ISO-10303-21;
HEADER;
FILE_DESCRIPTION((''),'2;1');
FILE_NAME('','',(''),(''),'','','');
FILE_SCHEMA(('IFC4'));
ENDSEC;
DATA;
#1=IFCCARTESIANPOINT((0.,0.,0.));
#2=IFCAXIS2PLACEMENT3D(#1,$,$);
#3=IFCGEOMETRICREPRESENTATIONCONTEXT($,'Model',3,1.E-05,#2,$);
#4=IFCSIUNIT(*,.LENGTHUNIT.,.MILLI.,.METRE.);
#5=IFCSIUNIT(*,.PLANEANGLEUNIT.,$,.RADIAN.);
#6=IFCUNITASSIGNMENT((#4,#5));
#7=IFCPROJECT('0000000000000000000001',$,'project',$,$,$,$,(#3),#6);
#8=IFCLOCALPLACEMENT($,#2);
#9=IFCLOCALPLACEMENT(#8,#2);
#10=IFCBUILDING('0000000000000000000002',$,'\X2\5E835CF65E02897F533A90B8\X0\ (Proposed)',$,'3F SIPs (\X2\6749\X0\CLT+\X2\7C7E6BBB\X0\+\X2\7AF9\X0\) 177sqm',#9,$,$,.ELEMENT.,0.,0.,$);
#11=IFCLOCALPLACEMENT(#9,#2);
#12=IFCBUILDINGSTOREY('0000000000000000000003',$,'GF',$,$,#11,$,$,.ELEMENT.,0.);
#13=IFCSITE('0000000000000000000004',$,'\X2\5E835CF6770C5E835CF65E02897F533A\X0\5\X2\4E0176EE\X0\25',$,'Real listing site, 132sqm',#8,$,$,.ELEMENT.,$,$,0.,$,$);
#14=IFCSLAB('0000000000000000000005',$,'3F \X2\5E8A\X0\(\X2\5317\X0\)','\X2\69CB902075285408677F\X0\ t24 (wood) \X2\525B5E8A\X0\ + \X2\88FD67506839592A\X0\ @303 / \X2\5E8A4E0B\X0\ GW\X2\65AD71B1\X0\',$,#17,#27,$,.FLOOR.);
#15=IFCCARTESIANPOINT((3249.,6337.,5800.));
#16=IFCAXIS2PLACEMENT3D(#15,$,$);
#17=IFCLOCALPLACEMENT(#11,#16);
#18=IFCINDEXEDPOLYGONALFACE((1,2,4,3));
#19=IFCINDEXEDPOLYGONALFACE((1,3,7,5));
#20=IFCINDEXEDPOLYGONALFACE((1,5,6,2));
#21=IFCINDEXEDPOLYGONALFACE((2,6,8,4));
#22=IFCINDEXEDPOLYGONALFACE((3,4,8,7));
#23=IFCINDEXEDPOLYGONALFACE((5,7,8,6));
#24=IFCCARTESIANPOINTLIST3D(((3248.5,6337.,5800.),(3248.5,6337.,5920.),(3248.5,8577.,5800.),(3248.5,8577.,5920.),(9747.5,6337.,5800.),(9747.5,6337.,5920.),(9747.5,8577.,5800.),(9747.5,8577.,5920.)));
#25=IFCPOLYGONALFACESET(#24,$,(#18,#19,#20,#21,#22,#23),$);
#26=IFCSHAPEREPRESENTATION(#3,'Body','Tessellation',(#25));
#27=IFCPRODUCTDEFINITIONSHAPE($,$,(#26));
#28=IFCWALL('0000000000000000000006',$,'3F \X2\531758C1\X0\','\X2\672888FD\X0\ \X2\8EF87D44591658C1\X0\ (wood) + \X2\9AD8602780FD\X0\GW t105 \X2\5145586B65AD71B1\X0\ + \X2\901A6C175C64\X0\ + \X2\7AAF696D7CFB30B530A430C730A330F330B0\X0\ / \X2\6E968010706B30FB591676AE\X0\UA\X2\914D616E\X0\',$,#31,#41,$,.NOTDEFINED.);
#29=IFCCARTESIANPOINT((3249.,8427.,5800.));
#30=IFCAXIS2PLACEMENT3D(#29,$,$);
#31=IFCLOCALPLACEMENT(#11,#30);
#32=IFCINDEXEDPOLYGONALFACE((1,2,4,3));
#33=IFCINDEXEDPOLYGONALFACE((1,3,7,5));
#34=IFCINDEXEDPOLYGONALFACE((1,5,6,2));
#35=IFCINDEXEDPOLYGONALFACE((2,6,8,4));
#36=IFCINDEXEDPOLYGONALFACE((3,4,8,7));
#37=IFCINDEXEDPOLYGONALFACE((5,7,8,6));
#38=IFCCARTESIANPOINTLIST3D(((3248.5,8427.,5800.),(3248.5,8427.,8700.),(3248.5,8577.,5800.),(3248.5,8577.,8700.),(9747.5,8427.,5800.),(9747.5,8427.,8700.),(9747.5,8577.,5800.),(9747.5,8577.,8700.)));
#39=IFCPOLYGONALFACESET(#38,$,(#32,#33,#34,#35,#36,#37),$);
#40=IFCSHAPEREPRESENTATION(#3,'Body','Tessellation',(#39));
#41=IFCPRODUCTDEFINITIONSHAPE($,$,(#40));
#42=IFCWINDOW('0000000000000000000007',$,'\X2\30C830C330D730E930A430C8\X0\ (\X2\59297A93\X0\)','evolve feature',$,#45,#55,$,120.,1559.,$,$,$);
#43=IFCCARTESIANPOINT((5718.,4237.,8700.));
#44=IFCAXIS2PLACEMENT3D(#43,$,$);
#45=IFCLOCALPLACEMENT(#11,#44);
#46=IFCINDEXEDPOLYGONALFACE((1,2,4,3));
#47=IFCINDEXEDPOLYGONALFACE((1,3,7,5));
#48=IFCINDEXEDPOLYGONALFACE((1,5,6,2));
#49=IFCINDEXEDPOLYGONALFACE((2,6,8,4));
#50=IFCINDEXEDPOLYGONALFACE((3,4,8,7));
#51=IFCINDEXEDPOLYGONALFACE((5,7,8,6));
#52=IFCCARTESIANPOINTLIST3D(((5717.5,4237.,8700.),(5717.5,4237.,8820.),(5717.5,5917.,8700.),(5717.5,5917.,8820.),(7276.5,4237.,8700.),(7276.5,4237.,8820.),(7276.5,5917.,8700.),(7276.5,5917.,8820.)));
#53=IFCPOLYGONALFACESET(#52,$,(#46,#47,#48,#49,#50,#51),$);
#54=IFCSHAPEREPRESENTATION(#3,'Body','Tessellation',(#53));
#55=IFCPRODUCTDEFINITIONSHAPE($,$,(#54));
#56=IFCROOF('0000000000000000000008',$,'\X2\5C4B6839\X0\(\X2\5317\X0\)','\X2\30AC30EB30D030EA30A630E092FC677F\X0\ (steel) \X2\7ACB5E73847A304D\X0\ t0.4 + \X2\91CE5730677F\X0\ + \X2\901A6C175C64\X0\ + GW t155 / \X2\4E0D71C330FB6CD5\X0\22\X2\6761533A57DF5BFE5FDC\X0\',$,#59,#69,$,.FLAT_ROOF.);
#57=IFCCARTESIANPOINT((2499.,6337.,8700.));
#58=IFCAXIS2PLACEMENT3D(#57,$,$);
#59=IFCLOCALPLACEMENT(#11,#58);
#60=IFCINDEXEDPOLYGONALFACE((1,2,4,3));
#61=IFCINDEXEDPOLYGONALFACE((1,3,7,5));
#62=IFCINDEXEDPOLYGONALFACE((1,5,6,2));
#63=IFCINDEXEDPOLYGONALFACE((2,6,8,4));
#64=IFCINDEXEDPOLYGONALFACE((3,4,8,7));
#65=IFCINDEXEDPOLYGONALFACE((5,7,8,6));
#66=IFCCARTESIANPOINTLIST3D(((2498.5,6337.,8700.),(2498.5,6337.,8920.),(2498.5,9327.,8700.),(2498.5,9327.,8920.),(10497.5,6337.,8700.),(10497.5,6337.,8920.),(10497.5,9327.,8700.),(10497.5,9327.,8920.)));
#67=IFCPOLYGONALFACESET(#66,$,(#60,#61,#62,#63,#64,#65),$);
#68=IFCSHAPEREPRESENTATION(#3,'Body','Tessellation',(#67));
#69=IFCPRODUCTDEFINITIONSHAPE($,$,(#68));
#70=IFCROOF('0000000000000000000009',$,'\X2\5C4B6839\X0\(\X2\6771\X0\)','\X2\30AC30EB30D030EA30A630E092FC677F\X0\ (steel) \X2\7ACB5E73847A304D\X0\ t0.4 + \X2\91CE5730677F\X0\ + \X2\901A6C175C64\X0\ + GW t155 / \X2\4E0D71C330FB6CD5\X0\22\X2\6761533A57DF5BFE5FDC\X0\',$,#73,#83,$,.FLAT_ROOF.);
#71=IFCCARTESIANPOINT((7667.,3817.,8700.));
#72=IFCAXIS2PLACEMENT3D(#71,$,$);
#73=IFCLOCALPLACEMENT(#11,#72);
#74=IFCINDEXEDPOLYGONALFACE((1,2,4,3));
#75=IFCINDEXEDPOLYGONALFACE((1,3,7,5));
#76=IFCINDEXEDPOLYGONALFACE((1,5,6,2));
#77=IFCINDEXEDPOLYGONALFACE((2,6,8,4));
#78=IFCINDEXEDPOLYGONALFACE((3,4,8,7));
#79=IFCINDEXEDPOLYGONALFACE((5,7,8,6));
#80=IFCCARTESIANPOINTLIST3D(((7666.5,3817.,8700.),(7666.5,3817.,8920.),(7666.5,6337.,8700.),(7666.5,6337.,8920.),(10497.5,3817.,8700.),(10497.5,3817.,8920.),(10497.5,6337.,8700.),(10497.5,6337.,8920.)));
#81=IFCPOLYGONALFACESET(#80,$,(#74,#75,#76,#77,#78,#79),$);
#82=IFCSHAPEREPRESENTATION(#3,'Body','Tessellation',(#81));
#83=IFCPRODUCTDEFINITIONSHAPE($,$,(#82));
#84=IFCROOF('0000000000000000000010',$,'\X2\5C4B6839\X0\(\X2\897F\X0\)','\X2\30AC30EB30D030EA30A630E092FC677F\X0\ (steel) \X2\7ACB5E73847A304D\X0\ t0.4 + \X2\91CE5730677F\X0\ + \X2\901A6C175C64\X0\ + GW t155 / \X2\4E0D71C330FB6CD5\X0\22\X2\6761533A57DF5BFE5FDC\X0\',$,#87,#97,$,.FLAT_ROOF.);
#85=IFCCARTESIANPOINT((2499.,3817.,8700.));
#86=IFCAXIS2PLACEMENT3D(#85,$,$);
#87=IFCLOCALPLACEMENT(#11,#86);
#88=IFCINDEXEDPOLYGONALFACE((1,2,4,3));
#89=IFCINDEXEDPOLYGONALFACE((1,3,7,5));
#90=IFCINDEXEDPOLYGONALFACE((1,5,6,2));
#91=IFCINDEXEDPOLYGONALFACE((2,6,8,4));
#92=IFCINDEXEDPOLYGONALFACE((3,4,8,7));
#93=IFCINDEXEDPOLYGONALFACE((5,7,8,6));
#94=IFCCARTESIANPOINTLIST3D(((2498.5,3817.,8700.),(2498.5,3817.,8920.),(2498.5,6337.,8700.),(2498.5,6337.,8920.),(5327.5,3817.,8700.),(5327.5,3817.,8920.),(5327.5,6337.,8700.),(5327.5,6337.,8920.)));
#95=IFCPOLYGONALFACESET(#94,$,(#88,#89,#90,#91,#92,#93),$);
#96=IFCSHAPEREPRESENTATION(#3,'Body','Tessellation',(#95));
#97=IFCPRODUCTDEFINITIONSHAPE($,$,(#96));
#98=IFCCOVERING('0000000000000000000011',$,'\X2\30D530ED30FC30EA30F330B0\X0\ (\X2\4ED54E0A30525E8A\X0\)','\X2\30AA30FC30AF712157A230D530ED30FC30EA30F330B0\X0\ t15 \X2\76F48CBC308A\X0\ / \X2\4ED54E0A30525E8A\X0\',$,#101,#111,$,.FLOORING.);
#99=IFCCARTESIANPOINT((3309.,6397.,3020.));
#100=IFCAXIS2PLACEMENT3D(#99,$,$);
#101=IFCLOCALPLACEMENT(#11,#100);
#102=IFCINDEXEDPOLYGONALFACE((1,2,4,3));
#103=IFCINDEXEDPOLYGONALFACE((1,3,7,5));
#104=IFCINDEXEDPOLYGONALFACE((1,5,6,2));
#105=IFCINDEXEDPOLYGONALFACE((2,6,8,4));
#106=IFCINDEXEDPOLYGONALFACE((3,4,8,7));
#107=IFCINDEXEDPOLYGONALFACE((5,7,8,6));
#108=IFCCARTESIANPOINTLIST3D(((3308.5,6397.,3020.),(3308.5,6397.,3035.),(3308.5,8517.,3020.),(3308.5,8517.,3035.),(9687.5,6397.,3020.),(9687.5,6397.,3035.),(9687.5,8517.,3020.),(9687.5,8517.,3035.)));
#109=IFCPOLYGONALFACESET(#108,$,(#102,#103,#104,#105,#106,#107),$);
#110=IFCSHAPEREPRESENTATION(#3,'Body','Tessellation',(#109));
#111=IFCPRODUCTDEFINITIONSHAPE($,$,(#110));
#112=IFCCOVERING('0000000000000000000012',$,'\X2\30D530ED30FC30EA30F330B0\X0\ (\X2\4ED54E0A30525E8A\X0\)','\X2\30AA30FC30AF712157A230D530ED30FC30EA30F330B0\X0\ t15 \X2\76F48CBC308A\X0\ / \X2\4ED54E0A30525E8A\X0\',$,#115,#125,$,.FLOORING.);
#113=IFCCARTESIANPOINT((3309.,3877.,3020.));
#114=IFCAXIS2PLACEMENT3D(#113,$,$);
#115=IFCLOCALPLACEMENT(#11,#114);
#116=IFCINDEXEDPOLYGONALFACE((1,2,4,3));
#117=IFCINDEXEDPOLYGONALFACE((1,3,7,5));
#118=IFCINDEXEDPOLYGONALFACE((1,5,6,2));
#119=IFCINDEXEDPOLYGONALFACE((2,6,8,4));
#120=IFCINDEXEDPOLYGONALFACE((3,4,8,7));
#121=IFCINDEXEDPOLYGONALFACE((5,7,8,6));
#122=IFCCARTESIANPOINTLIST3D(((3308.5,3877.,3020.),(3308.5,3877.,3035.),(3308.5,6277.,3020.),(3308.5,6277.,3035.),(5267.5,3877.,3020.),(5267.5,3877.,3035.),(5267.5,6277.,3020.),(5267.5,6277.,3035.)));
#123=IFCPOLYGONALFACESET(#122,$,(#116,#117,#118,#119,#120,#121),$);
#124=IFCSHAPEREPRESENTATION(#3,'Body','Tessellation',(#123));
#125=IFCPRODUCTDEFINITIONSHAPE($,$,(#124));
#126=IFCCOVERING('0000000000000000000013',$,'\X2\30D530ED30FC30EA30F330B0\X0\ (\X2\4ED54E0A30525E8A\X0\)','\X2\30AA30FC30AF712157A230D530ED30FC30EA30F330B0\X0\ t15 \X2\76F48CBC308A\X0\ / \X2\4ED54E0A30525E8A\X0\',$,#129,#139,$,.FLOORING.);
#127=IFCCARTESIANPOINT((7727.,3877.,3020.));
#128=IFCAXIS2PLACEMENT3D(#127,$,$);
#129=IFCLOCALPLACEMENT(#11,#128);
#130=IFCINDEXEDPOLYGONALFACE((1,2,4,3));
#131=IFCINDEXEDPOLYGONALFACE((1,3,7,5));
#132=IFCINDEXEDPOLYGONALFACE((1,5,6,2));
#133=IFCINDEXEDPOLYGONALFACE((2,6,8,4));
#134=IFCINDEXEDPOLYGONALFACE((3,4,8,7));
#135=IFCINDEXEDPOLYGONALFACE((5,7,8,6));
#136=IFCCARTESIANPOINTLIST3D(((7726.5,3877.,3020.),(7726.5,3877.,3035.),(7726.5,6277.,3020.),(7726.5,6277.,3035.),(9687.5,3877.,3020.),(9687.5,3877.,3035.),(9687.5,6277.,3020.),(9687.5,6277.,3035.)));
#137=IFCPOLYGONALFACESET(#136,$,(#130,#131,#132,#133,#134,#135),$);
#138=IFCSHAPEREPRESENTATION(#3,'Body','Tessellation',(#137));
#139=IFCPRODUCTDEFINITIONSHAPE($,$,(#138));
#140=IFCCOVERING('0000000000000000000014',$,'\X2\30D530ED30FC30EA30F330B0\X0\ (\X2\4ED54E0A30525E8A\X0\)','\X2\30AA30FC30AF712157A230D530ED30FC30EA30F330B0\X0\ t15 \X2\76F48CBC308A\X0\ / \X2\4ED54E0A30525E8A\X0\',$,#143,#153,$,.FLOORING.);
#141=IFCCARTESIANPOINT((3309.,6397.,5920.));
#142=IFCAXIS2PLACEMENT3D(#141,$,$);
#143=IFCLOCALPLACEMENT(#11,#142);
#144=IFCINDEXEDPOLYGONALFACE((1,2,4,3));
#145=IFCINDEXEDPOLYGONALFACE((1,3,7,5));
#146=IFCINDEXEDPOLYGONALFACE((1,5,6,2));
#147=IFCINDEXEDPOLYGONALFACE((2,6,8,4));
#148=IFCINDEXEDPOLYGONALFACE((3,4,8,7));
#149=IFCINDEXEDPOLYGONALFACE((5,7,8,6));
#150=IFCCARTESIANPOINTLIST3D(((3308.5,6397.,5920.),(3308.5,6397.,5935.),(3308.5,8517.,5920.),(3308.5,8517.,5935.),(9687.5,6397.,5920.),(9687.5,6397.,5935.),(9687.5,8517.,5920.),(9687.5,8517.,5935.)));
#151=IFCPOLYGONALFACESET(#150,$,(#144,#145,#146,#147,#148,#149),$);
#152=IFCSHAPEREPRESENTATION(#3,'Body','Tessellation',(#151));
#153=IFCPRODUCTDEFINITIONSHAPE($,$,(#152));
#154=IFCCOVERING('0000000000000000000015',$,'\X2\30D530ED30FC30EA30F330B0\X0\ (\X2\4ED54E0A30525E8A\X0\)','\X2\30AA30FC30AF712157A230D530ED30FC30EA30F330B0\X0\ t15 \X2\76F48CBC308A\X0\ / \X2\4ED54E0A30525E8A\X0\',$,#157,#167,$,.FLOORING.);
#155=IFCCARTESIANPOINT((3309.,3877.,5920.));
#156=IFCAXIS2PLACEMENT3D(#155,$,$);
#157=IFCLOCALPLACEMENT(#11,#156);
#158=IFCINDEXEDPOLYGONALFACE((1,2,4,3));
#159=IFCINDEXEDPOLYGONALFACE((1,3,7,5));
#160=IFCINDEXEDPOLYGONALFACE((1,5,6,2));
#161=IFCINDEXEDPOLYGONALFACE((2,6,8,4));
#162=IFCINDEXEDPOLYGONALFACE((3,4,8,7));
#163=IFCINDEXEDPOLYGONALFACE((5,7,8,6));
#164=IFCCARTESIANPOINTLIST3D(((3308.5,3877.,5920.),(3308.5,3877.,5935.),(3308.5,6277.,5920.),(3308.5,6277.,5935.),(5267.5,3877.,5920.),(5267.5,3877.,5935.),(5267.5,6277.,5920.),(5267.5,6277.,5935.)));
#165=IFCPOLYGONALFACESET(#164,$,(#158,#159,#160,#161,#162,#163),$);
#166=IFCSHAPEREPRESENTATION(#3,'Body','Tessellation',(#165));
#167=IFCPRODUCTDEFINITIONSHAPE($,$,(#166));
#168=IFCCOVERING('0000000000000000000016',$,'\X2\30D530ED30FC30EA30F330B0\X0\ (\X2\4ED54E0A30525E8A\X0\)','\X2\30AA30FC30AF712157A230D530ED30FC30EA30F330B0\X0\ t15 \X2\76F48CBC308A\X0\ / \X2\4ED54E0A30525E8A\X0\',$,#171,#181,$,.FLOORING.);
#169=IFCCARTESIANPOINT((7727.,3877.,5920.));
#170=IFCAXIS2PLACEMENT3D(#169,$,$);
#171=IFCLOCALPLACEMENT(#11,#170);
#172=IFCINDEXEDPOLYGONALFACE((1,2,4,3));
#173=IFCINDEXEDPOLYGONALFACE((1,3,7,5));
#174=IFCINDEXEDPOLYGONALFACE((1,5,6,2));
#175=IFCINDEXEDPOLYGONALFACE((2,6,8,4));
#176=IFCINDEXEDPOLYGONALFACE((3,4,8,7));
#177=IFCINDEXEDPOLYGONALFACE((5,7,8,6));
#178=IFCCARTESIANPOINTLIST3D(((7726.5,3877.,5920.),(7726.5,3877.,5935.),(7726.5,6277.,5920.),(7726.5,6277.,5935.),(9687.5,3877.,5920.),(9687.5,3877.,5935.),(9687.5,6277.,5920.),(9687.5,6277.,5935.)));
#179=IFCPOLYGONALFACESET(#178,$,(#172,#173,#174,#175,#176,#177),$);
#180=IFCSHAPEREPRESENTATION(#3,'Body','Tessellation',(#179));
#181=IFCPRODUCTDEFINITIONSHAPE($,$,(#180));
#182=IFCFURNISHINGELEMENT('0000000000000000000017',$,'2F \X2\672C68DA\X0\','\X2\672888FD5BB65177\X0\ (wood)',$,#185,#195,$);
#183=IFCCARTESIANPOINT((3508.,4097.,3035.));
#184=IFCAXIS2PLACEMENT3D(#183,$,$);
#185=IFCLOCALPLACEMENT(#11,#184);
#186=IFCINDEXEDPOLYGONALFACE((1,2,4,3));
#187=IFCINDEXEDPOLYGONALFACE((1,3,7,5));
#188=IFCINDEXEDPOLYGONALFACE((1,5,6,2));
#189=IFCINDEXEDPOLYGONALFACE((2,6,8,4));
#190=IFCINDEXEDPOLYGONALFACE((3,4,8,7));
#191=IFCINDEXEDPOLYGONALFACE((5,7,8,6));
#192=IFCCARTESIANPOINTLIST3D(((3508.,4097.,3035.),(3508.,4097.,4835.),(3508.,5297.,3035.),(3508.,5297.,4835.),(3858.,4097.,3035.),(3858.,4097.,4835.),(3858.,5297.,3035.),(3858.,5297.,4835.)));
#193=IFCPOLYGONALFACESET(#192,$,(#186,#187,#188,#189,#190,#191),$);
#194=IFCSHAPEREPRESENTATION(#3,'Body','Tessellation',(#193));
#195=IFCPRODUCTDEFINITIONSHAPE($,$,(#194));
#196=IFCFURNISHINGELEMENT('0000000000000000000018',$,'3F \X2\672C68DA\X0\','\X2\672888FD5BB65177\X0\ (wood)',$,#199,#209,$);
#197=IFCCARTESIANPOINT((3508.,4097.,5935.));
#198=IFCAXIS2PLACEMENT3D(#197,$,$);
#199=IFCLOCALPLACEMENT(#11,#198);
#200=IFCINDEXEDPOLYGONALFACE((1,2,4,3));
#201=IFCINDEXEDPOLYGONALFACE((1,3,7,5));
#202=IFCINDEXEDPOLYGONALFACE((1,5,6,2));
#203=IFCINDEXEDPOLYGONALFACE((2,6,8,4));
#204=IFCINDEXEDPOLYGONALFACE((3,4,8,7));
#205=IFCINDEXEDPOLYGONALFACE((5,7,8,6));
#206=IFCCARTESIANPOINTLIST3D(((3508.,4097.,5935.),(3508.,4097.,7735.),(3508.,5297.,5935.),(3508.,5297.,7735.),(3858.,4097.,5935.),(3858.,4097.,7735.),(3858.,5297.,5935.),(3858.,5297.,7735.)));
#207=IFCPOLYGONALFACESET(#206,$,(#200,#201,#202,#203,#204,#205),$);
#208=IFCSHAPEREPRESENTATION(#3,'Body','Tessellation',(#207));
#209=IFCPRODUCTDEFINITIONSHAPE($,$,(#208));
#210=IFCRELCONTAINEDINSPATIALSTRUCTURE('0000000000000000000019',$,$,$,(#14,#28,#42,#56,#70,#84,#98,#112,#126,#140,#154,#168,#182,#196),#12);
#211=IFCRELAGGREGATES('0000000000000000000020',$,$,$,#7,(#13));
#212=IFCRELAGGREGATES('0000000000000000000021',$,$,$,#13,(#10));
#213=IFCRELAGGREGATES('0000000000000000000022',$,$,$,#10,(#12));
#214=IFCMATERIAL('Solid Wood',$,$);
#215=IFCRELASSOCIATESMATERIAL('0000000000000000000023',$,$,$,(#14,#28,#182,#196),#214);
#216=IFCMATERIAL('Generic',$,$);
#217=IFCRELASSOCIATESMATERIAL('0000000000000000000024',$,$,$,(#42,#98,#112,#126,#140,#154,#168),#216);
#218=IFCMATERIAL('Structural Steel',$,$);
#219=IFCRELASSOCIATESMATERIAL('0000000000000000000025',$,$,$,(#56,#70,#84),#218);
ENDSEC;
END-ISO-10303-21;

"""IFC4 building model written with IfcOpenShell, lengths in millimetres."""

from ifc_helpers import new_model, si_unit, frame, frame_2d, origin, place, context, project, spatial, rectangle, extrude, material, element, save


model = new_model("IFC4")

# Units and contexts
model_context = context("Model", 3, precision=1e-05, world=origin())
ifc_project = project(units=[si_unit("LENGTHUNIT", "METRE", prefix="MILLI"), si_unit("PLANEANGLEUNIT", "RADIAN")], contexts=[model_context])

# Site, building, storey
site_placement = place(None, origin())
site = spatial("IfcSite", under=ifc_project, at=site_placement, Name="広島県広島市西区5丁目25", ObjectType="Real listing site, 132sqm", CompositionType="ELEMENT", RefElevation=0.0)
building_placement = place(site_placement, origin())
building = spatial("IfcBuilding", under=site, at=building_placement, Name="広島市西区邸 (Proposed)", ObjectType="3F SIPs (杉CLT+籾殻+竹) 177sqm", CompositionType="ELEMENT", ElevationOfRefHeight=0.0, ElevationOfTerrain=0.0)
storey_placement = place(building_placement, origin())
storey = spatial("IfcBuildingStorey", under=building, at=storey_placement, Name="GF", CompositionType="ELEMENT", Elevation=0.0)

# Slab
ifc_material_1 = material(Name="Solid Wood")
slab_placement = place(storey_placement, frame((3249.0, 6337.0, 5800.0)))
element("IfcSlab", 1, at=slab_placement, inside=storey, material=ifc_material_1, Name="3F 床(北)", Description="構造用合板 t24 (wood) 剛床 + 製材根太 @303 / 床下 GW断熱", PredefinedType="FLOOR", context=model_context, shape_type="SweptSolid", body=[
    extrude(rectangle(XDim=6499.0, YDim=2240.0, at=frame_2d((3249.0, 1120.0))), frame((3249.0, 6337.0, 5800.0)), (0.0, 0.0, 1.0), 120.0),
])

# Wall
wall_1_placement = place(storey_placement, frame((3249.0, 8427.0, 5800.0)))
element("IfcWall", 2, at=wall_1_placement, inside=storey, material=ifc_material_1, Name="3F 北壁", Description="木製 軸組外壁 (wood) + 高性能GW t105 充填断熱 + 通気層 + 窯業系サイディング / 準耐火・外皮UA配慮", PredefinedType="NOTDEFINED", context=model_context, shape_type="SweptSolid", body=[
    extrude(rectangle(XDim=6499.0, YDim=150.0, at=frame_2d((3249.0, 75.0))), frame((3249.0, 8427.0, 5800.0)), (0.0, 0.0, 1.0), 2900.0),
])

# Window
ifc_material_2 = material(Name="Generic")
window_1_placement = place(storey_placement, frame((5718.0, 4237.0, 8700.0)))
element("IfcWindow", 3, at=window_1_placement, inside=storey, material=ifc_material_2, Name="トップライト (天窓)", Description="evolve feature", OverallHeight=120.0, OverallWidth=1559.0, context=model_context, shape_type="SweptSolid", body=[
    extrude(rectangle(XDim=1559.0, YDim=1680.0, at=frame_2d((779.0, 840.0))), frame((5718.0, 4237.0, 8700.0)), (0.0, 0.0, 1.0), 120.0),
])

# Roofs
ifc_material_3 = material(Name="Structural Steel")
roof_1_placement = place(storey_placement, frame((2499.0, 6337.0, 8700.0)))
element("IfcRoof", 4, at=roof_1_placement, inside=storey, material=ifc_material_3, Name="屋根(北)", Description="ガルバリウム鋼板 (steel) 立平葺き t0.4 + 野地板 + 通気層 + GW t155 / 不燃・法22条区域対応", PredefinedType="FLAT_ROOF", context=model_context, shape_type="SweptSolid", body=[
    extrude(rectangle(XDim=7999.0, YDim=2990.0, at=frame_2d((3999.0, 1495.0))), frame((2499.0, 6337.0, 8700.0)), (0.0, 0.0, 1.0), 220.0),
])
roof_2_placement = place(storey_placement, frame((7667.0, 3817.0, 8700.0)))
element("IfcRoof", 5, at=roof_2_placement, inside=storey, material=ifc_material_3, Name="屋根(東)", Description="ガルバリウム鋼板 (steel) 立平葺き t0.4 + 野地板 + 通気層 + GW t155 / 不燃・法22条区域対応", PredefinedType="FLAT_ROOF", context=model_context, shape_type="SweptSolid", body=[
    extrude(rectangle(XDim=2831.0, YDim=2520.0, at=frame_2d((1415.0, 1260.0))), frame((7667.0, 3817.0, 8700.0)), (0.0, 0.0, 1.0), 220.0),
])
roof_3_placement = place(storey_placement, frame((2499.0, 3817.0, 8700.0)))
element("IfcRoof", 6, at=roof_3_placement, inside=storey, material=ifc_material_3, Name="屋根(西)", Description="ガルバリウム鋼板 (steel) 立平葺き t0.4 + 野地板 + 通気層 + GW t155 / 不燃・法22条区域対応", PredefinedType="FLAT_ROOF", context=model_context, shape_type="SweptSolid", body=[
    extrude(rectangle(XDim=2829.0, YDim=2520.0, at=frame_2d((1414.0, 1260.0))), frame((2499.0, 3817.0, 8700.0)), (0.0, 0.0, 1.0), 220.0),
])

# Coverings
covering_1_placement = place(storey_placement, frame((3309.0, 6397.0, 3020.0)))
element("IfcCovering", 7, at=covering_1_placement, inside=storey, material=ifc_material_2, Name="フローリング (仕上げ床)", Description="オーク無垢フローリング t15 直貼り / 仕上げ床", PredefinedType="FLOORING", context=model_context, shape_type="SweptSolid", body=[
    extrude(rectangle(XDim=6379.0, YDim=2120.0, at=frame_2d((3189.0, 1060.0))), frame((3309.0, 6397.0, 3020.0)), (0.0, 0.0, 1.0), 15.0),
])
covering_2_placement = place(storey_placement, frame((3309.0, 3877.0, 3020.0)))
element("IfcCovering", 8, at=covering_2_placement, inside=storey, material=ifc_material_2, Name="フローリング (仕上げ床)", Description="オーク無垢フローリング t15 直貼り / 仕上げ床", PredefinedType="FLOORING", context=model_context, shape_type="SweptSolid", body=[
    extrude(rectangle(XDim=1959.0, YDim=2400.0, at=frame_2d((979.0, 1200.0))), frame((3309.0, 3877.0, 3020.0)), (0.0, 0.0, 1.0), 15.0),
])
covering_3_placement = place(storey_placement, frame((7727.0, 3877.0, 3020.0)))
element("IfcCovering", 9, at=covering_3_placement, inside=storey, material=ifc_material_2, Name="フローリング (仕上げ床)", Description="オーク無垢フローリング t15 直貼り / 仕上げ床", PredefinedType="FLOORING", context=model_context, shape_type="SweptSolid", body=[
    extrude(rectangle(XDim=1961.0, YDim=2400.0, at=frame_2d((980.0, 1200.0))), frame((7727.0, 3877.0, 3020.0)), (0.0, 0.0, 1.0), 15.0),
])
covering_4_placement = place(storey_placement, frame((3309.0, 6397.0, 5920.0)))
element("IfcCovering", 10, at=covering_4_placement, inside=storey, material=ifc_material_2, Name="フローリング (仕上げ床)", Description="オーク無垢フローリング t15 直貼り / 仕上げ床", PredefinedType="FLOORING", context=model_context, shape_type="SweptSolid", body=[
    extrude(rectangle(XDim=6379.0, YDim=2120.0, at=frame_2d((3189.0, 1060.0))), frame((3309.0, 6397.0, 5920.0)), (0.0, 0.0, 1.0), 15.0),
])
covering_5_placement = place(storey_placement, frame((3309.0, 3877.0, 5920.0)))
element("IfcCovering", 11, at=covering_5_placement, inside=storey, material=ifc_material_2, Name="フローリング (仕上げ床)", Description="オーク無垢フローリング t15 直貼り / 仕上げ床", PredefinedType="FLOORING", context=model_context, shape_type="SweptSolid", body=[
    extrude(rectangle(XDim=1959.0, YDim=2400.0, at=frame_2d((979.0, 1200.0))), frame((3309.0, 3877.0, 5920.0)), (0.0, 0.0, 1.0), 15.0),
])
covering_6_placement = place(storey_placement, frame((7727.0, 3877.0, 5920.0)))
element("IfcCovering", 12, at=covering_6_placement, inside=storey, material=ifc_material_2, Name="フローリング (仕上げ床)", Description="オーク無垢フローリング t15 直貼り / 仕上げ床", PredefinedType="FLOORING", context=model_context, shape_type="SweptSolid", body=[
    extrude(rectangle(XDim=1961.0, YDim=2400.0, at=frame_2d((980.0, 1200.0))), frame((7727.0, 3877.0, 5920.0)), (0.0, 0.0, 1.0), 15.0),
])

# Furnishing elements
furnishing_1_placement = place(storey_placement, frame((3508.0, 4097.0, 3035.0)))
element("IfcFurnishingElement", 13, at=furnishing_1_placement, inside=storey, material=ifc_material_1, Name="2F 本棚", Description="木製家具 (wood)", context=model_context, shape_type="SweptSolid", body=[
    extrude(rectangle(XDim=350.0, YDim=1200.0, at=frame_2d((175.0, 600.0))), frame((3508.0, 4097.0, 3035.0)), (0.0, 0.0, 1.0), 1800.0),
])
furnishing_2_placement = place(storey_placement, frame((3508.0, 4097.0, 5935.0)))
element("IfcFurnishingElement", 14, at=furnishing_2_placement, inside=storey, material=ifc_material_1, Name="3F 本棚", Description="木製家具 (wood)", context=model_context, shape_type="SweptSolid", body=[
    extrude(rectangle(XDim=350.0, YDim=1200.0, at=frame_2d((175.0, 600.0))), frame((3508.0, 4097.0, 5935.0)), (0.0, 0.0, 1.0), 1800.0),
])

save(model, "model.ifc")
